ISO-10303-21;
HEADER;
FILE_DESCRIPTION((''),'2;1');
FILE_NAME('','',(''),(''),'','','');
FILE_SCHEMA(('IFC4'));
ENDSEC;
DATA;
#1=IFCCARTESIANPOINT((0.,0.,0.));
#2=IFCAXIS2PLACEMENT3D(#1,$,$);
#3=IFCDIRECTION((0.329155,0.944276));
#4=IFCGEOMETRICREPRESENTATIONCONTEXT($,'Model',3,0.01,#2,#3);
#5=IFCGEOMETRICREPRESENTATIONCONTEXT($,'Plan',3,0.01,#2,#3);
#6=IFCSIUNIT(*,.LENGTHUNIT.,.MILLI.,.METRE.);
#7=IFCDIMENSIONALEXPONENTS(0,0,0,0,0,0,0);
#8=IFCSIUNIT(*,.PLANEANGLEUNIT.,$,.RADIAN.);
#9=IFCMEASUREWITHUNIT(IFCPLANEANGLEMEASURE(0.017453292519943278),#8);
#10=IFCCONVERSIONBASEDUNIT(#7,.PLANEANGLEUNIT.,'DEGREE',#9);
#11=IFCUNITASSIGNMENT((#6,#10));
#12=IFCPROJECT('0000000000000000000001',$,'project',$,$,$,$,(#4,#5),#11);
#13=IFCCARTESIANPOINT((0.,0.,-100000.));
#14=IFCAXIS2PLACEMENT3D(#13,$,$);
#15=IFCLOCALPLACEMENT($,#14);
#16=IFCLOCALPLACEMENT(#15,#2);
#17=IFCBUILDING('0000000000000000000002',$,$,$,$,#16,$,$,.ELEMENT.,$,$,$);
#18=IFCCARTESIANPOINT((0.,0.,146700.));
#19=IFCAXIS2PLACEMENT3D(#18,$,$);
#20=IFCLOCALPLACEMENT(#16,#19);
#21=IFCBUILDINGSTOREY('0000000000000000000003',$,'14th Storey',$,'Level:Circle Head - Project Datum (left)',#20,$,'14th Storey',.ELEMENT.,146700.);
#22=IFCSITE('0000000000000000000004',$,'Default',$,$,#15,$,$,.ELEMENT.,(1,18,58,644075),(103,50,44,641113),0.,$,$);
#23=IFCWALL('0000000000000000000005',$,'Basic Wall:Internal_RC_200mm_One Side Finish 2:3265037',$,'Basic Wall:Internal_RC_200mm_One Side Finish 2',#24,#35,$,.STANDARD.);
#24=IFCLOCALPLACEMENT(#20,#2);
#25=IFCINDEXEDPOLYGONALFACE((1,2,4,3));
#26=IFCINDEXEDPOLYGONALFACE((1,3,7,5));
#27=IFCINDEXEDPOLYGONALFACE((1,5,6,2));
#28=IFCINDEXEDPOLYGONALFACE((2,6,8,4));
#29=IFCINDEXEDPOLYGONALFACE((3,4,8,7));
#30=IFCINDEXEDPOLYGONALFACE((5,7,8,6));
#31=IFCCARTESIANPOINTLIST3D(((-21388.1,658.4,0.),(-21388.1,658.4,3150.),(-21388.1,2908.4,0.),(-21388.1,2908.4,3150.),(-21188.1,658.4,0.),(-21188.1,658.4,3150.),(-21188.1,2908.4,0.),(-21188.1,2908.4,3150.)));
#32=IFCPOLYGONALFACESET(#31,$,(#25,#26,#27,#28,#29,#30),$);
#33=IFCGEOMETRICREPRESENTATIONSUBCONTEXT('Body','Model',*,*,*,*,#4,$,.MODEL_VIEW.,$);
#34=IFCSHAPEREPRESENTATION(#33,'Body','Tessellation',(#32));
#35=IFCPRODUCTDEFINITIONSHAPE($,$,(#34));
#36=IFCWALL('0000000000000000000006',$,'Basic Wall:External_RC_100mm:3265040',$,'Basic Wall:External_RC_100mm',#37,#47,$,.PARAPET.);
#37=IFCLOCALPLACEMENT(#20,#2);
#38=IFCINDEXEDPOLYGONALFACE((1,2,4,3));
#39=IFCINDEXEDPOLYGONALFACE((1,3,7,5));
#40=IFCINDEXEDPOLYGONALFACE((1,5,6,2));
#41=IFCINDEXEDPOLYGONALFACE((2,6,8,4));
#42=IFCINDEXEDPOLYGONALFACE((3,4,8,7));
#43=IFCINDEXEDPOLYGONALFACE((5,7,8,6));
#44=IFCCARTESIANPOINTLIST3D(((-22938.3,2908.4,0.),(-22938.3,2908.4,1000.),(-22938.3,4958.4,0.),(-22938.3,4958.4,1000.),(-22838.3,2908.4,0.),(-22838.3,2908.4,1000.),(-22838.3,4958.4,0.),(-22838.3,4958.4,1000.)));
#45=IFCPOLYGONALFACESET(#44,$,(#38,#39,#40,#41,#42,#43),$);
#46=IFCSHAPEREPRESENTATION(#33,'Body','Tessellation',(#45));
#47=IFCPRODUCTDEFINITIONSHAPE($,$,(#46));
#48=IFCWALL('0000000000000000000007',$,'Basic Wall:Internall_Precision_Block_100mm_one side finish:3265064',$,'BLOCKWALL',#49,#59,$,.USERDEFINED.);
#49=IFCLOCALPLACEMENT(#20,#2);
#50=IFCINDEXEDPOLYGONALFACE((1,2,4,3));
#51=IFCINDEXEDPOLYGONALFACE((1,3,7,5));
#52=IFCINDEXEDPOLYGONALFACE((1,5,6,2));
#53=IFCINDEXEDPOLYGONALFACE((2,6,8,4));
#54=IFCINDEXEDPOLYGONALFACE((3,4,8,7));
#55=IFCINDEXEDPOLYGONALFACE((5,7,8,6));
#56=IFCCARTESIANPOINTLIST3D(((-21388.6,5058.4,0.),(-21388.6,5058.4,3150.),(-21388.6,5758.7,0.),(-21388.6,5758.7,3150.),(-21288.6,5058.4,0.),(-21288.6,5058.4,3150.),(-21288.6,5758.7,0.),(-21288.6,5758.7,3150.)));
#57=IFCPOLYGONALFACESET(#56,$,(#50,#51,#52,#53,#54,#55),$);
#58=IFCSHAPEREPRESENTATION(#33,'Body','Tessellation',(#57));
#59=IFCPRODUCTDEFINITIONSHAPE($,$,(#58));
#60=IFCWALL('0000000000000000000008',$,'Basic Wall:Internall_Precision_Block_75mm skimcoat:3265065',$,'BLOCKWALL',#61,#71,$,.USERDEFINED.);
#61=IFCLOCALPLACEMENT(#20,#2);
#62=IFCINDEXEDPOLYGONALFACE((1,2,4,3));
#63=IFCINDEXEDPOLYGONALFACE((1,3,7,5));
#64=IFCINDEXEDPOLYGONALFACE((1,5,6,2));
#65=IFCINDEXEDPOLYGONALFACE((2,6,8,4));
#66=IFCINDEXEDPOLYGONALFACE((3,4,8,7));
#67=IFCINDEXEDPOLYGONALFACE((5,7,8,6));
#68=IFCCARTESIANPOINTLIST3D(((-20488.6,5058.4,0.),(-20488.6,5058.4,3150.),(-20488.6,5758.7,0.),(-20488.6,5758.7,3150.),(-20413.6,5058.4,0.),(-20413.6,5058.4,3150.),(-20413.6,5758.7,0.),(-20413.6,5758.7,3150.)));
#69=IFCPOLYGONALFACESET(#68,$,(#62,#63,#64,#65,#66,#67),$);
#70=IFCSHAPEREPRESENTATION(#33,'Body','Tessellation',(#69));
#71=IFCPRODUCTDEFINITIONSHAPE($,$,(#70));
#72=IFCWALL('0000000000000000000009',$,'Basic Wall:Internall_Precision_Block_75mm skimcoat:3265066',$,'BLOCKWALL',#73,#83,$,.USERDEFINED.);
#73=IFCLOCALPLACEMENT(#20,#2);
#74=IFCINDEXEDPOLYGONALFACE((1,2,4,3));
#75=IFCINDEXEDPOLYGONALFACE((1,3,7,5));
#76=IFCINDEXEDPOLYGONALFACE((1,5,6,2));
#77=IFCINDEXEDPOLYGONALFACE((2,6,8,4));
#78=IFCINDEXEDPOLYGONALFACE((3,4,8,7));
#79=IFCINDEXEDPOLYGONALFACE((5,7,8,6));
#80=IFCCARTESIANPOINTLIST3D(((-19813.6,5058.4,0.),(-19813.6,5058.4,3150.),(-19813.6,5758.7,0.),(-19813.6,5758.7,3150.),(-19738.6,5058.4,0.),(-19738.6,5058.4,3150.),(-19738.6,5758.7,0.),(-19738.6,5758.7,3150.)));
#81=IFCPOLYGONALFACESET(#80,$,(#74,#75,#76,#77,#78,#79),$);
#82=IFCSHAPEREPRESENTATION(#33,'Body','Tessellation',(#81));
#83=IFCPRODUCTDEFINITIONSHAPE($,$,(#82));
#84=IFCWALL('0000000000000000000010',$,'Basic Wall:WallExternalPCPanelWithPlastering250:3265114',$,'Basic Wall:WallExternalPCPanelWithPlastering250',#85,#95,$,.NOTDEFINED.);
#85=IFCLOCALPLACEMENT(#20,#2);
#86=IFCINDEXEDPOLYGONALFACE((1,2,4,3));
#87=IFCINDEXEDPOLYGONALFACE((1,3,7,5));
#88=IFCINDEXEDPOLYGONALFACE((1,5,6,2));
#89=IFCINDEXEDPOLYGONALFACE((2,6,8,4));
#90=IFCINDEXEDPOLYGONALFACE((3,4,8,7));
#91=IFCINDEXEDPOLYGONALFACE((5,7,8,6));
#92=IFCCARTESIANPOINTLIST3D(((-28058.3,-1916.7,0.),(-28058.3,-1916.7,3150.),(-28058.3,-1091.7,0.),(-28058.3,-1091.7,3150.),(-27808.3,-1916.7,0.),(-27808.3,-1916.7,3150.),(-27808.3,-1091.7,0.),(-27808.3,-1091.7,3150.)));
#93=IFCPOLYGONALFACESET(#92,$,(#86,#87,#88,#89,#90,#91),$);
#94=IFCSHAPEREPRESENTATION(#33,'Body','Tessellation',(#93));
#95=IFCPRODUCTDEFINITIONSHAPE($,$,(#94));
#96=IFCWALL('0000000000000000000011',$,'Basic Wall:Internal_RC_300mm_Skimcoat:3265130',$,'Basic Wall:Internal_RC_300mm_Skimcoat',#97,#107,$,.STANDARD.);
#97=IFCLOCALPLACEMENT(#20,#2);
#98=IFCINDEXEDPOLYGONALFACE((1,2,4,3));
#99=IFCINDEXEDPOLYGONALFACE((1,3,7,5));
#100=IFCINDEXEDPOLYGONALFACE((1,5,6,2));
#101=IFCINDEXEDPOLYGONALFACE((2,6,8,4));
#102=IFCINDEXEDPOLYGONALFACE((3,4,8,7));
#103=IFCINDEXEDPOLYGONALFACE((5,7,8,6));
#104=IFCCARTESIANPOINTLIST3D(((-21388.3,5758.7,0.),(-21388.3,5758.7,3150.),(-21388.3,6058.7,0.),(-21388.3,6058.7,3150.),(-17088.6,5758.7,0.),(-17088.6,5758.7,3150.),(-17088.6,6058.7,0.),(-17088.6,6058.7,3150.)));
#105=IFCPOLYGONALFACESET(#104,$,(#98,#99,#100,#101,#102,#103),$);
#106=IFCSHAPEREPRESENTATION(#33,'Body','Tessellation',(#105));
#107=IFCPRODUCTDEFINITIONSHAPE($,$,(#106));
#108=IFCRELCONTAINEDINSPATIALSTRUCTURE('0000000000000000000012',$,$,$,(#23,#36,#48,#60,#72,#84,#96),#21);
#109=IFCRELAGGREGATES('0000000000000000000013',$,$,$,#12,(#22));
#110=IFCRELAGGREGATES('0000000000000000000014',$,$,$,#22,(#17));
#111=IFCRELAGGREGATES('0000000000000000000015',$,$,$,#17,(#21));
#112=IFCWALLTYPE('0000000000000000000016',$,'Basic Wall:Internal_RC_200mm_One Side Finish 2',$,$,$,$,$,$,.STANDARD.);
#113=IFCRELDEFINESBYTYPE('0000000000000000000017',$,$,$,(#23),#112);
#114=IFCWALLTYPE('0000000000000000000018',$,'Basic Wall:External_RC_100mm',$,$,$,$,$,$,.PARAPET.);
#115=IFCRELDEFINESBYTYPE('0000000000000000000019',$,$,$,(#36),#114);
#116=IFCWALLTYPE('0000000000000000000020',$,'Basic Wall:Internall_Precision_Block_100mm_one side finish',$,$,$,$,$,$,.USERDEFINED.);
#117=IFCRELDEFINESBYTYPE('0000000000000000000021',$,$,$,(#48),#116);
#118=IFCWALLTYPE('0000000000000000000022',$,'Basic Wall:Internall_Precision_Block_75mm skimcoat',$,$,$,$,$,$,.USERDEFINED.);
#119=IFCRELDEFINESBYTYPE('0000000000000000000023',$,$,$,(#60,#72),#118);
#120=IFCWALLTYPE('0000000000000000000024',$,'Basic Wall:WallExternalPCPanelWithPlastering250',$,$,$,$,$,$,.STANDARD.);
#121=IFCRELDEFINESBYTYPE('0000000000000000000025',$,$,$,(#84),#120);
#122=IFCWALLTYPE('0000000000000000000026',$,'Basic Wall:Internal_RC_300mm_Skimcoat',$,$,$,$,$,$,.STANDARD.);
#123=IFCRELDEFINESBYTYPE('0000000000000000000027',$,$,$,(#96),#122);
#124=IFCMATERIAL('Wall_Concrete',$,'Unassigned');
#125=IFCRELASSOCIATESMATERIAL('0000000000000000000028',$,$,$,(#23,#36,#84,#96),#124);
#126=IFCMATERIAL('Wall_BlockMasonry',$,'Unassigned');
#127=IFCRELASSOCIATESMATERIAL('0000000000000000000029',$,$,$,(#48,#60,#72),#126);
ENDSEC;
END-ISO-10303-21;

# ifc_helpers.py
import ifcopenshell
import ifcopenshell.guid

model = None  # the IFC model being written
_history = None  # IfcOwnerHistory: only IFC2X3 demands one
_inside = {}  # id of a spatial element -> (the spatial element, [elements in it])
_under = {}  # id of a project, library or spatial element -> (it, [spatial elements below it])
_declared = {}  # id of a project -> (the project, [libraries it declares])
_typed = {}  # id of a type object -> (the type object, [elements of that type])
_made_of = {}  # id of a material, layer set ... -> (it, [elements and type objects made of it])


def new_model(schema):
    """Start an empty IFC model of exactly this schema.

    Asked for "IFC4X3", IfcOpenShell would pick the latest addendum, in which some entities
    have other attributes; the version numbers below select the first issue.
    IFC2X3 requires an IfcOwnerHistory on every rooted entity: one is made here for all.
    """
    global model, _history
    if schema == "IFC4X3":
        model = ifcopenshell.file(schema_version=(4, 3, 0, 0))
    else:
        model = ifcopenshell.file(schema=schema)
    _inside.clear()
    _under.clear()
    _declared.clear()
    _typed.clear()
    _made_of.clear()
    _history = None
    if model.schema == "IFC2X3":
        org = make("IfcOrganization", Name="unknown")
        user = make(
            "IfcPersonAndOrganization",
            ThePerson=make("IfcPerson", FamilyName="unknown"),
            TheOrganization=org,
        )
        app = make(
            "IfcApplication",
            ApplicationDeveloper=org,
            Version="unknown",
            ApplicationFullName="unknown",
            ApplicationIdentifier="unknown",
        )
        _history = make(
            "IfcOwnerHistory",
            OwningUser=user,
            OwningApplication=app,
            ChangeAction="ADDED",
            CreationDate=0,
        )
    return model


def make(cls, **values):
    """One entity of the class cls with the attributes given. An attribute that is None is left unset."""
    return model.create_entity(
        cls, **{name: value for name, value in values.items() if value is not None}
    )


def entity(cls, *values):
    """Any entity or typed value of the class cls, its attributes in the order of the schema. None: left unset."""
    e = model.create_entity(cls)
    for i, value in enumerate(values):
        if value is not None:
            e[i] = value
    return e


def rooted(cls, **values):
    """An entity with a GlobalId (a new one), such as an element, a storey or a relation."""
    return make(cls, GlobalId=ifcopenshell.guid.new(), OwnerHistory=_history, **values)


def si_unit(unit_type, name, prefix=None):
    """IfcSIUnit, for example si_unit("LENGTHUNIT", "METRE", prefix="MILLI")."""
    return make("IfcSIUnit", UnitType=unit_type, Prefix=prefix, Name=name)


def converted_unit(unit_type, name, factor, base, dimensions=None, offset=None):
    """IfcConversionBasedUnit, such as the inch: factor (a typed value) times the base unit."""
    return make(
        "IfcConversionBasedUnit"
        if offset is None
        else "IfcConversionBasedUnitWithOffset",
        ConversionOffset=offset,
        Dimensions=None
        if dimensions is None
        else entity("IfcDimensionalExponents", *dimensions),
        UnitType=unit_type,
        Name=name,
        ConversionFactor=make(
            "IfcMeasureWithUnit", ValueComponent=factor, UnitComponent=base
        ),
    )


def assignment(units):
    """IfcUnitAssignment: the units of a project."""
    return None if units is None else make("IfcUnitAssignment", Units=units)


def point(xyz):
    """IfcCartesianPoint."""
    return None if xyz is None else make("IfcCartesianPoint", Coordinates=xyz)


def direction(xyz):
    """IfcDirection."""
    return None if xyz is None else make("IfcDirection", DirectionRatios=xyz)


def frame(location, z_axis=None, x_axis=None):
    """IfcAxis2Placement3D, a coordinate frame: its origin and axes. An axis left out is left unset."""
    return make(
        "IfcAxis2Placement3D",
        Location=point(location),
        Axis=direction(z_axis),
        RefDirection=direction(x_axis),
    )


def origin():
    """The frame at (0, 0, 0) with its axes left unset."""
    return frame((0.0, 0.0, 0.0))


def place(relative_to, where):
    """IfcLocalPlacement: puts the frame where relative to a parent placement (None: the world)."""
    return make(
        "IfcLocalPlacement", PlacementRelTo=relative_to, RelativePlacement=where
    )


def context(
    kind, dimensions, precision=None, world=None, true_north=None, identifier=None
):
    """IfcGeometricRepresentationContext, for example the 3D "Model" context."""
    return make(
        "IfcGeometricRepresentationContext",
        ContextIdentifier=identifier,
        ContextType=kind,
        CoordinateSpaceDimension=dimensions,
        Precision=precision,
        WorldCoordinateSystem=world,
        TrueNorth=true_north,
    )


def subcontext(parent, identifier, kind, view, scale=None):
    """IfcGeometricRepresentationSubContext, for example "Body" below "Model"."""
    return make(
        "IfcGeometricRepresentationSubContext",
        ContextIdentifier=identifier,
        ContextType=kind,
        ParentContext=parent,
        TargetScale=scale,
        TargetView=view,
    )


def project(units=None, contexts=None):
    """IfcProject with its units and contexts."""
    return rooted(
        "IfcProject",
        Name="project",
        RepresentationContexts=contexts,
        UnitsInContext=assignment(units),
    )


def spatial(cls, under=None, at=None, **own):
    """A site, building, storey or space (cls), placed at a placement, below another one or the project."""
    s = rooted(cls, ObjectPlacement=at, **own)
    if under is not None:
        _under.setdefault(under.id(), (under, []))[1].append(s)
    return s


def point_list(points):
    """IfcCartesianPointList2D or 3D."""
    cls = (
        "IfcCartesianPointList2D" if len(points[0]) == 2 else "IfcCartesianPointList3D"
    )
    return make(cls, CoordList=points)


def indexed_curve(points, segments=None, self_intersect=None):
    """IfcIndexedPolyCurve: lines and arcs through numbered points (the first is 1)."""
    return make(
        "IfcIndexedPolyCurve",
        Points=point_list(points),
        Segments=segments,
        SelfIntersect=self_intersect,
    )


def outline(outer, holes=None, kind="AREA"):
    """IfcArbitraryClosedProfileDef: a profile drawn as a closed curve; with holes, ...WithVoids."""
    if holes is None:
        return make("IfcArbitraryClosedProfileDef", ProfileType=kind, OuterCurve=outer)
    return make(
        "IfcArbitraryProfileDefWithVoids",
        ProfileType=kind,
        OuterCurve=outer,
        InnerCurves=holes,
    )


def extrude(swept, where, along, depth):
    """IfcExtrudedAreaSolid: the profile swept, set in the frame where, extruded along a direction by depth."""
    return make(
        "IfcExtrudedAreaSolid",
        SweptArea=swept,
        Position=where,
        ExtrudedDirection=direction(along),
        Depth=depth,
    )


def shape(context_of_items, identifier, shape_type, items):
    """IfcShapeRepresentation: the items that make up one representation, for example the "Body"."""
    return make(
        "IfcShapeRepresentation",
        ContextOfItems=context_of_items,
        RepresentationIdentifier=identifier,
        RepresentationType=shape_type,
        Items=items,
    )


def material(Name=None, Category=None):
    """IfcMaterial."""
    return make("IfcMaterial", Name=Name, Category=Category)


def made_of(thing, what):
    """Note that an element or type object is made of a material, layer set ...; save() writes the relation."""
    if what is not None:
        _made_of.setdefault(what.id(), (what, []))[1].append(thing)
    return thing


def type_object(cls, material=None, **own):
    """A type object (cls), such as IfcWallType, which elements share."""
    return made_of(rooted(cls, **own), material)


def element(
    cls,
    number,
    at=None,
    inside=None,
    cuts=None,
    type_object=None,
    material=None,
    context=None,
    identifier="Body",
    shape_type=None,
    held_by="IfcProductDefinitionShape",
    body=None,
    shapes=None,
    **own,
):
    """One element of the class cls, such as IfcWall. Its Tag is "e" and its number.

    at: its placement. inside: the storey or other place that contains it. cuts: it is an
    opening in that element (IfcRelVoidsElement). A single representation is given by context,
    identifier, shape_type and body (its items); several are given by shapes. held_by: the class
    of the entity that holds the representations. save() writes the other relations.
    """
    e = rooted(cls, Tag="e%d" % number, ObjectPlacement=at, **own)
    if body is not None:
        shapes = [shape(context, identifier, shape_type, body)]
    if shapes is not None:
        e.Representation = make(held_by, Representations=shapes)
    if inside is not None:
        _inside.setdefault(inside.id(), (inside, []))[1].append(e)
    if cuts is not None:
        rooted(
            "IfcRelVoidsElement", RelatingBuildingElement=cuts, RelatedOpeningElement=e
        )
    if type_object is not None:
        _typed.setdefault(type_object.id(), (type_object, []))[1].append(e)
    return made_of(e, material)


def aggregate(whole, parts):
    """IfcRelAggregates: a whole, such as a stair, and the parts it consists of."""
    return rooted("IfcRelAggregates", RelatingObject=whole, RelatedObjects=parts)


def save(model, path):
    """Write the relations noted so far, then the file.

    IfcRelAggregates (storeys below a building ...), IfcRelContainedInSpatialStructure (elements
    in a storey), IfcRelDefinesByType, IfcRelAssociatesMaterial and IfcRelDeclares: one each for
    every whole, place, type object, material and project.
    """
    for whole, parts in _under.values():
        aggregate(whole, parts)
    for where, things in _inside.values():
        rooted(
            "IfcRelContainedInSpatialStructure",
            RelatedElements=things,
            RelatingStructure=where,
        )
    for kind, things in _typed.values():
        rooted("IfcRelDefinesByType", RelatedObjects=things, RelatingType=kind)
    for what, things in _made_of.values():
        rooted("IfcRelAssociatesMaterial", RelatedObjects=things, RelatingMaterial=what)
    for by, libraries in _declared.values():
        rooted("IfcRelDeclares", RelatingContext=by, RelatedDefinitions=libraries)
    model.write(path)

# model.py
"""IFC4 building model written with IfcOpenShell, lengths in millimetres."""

from ifc_helpers import new_model, entity, si_unit, converted_unit, direction, frame, origin, place, context, subcontext, project, spatial, indexed_curve, outline, extrude, material, type_object, element, save


model = new_model("IFC4")

# Units and contexts
model_context = context("Model", 3, precision=0.01, world=origin(), true_north=direction((0.329155, 0.944276)))
plan_context = context("Plan", 3, precision=0.01, world=origin(), true_north=direction((0.329155, 0.944276)))
body_context = subcontext(model_context, "Body", "Model", "MODEL_VIEW")
ifc_project = project(units=[si_unit("LENGTHUNIT", "METRE", prefix="MILLI"), converted_unit("PLANEANGLEUNIT", "DEGREE", entity("IfcPlaneAngleMeasure", 0.017453292519943278), si_unit("PLANEANGLEUNIT", "RADIAN"), dimensions=[0, 0, 0, 0, 0, 0, 0])], contexts=[model_context, plan_context])

# Site, building, storey
site_placement = place(None, frame((0.0, 0.0, -100000.0)))
site = spatial("IfcSite", under=ifc_project, at=site_placement, Name="Default", CompositionType="ELEMENT", RefLatitude=(1, 18, 58, 644075), RefLongitude=(103, 50, 44, 641113), RefElevation=0.0)
building_placement = place(site_placement, origin())
building = spatial("IfcBuilding", under=site, at=building_placement, CompositionType="ELEMENT")
storey_placement = place(building_placement, frame((0.0, 0.0, 146700.0)))
storey = spatial("IfcBuildingStorey", under=building, at=storey_placement, Name="14th Storey", ObjectType="Level:Circle Head - Project Datum (left)", LongName="14th Storey", CompositionType="ELEMENT", Elevation=146700.0)

# Walls
ifc_material_1 = material(Name="Wall_Concrete", Category="Unassigned")
wall_type_1 = type_object("IfcWallType", Name="Basic Wall:Internal_RC_200mm_One Side Finish 2", PredefinedType="STANDARD")
wall_1_placement = place(storey_placement, frame((-21288.1, 658.4, 0.0), z_axis=(0.0, 0.0, 1.0), x_axis=(0.0, 1.0, 0.0)))
element("IfcWall", 1, at=wall_1_placement, inside=storey, type_object=wall_type_1, material=ifc_material_1, Name="Basic Wall:Internal_RC_200mm_One Side Finish 2:3265037", ObjectType="Basic Wall:Internal_RC_200mm_One Side Finish 2", PredefinedType="STANDARD", context=body_context, shape_type="SweptSolid", body=[
    extrude(outline(indexed_curve([(2250.0, 100.0), (0.0, 100.0), (0.0, -100.0), (2250.0, -100.0), (2250.0, 100.0)], self_intersect=False)), origin(), (0.0, 0.0, 1.0), 3150.0),
])
wall_type_2 = type_object("IfcWallType", Name="Basic Wall:External_RC_100mm", PredefinedType="PARAPET")
wall_2_placement = place(storey_placement, frame((-22888.3, 4958.4, 0.0), z_axis=(0.0, 0.0, 1.0), x_axis=(0.0, -1.0, 0.0)))
element("IfcWall", 2, at=wall_2_placement, inside=storey, type_object=wall_type_2, material=ifc_material_1, Name="Basic Wall:External_RC_100mm:3265040", ObjectType="Basic Wall:External_RC_100mm", PredefinedType="PARAPET", context=body_context, shape_type="SweptSolid", body=[
    extrude(outline(indexed_curve([(2050.0, 50.0), (0.0, 50.0), (0.0, -50.0), (2050.0, -50.0), (2050.0, 50.0)], self_intersect=False)), origin(), (0.0, 0.0, 1.0), 1000.0),
])
ifc_material_2 = material(Name="Wall_BlockMasonry", Category="Unassigned")
wall_type_3 = type_object("IfcWallType", Name="Basic Wall:Internall_Precision_Block_100mm_one side finish", PredefinedType="USERDEFINED")
wall_3_placement = place(storey_placement, frame((-21338.6, 5058.4, 0.0), z_axis=(0.0, 0.0, 1.0), x_axis=(0.0, 1.0, 0.0)))
element("IfcWall", 3, at=wall_3_placement, inside=storey, type_object=wall_type_3, material=ifc_material_2, Name="Basic Wall:Internall_Precision_Block_100mm_one side finish:3265064", ObjectType="BLOCKWALL", PredefinedType="USERDEFINED", context=body_context, shape_type="SweptSolid", body=[
    extrude(outline(indexed_curve([(700.4, 50.0), (0.0, 50.0), (0.0, -50.0), (700.4, -50.0), (700.4, 50.0)], self_intersect=False)), origin(), (0.0, 0.0, 1.0), 3150.0),
])
wall_type_4 = type_object("IfcWallType", Name="Basic Wall:Internall_Precision_Block_75mm skimcoat", PredefinedType="USERDEFINED")
wall_4_placement = place(storey_placement, frame((-20451.1, 5058.4, 0.0), z_axis=(0.0, 0.0, 1.0), x_axis=(0.0, 1.0, 0.0)))
element("IfcWall", 4, at=wall_4_placement, inside=storey, type_object=wall_type_4, material=ifc_material_2, Name="Basic Wall:Internall_Precision_Block_75mm skimcoat:3265065", ObjectType="BLOCKWALL", PredefinedType="USERDEFINED", context=body_context, shape_type="SweptSolid", body=[
    extrude(outline(indexed_curve([(700.4, 37.5), (0.0, 37.5), (0.0, -37.5), (700.4, -37.5), (700.4, 37.5)], self_intersect=False)), origin(), (0.0, 0.0, 1.0), 3150.0),
])
wall_5_placement = place(storey_placement, frame((-19776.1, 5058.4, 0.0), z_axis=(0.0, 0.0, 1.0), x_axis=(0.0, 1.0, 0.0)))
element("IfcWall", 5, at=wall_5_placement, inside=storey, type_object=wall_type_4, material=ifc_material_2, Name="Basic Wall:Internall_Precision_Block_75mm skimcoat:3265066", ObjectType="BLOCKWALL", PredefinedType="USERDEFINED", context=body_context, shape_type="SweptSolid", body=[
    extrude(outline(indexed_curve([(700.4, 37.5), (0.0, 37.5), (0.0, -37.5), (700.4, -37.5), (700.4, 37.5)], self_intersect=False)), origin(), (0.0, 0.0, 1.0), 3150.0),
])
wall_type_5 = type_object("IfcWallType", Name="Basic Wall:WallExternalPCPanelWithPlastering250", PredefinedType="STANDARD")
wall_6_placement = place(storey_placement, frame((-27933.3, -1916.7, 0.0), z_axis=(0.0, 0.0, 1.0), x_axis=(0.0, 1.0, 0.0)))
element("IfcWall", 6, at=wall_6_placement, inside=storey, type_object=wall_type_5, material=ifc_material_1, Name="Basic Wall:WallExternalPCPanelWithPlastering250:3265114", ObjectType="Basic Wall:WallExternalPCPanelWithPlastering250", PredefinedType="NOTDEFINED", context=body_context, shape_type="SweptSolid", body=[
    extrude(outline(indexed_curve([(825.0, 125.0), (0.0, 125.0), (0.0, -125.0), (825.0, -125.0), (825.0, 125.0)], self_intersect=False)), origin(), (0.0, 0.0, 1.0), 3150.0),
])
wall_type_6 = type_object("IfcWallType", Name="Basic Wall:Internal_RC_300mm_Skimcoat", PredefinedType="STANDARD")
wall_7_placement = place(storey_placement, frame((-21388.3, 5908.7, 0.0)))
element("IfcWall", 7, at=wall_7_placement, inside=storey, type_object=wall_type_6, material=ifc_material_1, Name="Basic Wall:Internal_RC_300mm_Skimcoat:3265130", ObjectType="Basic Wall:Internal_RC_300mm_Skimcoat", PredefinedType="STANDARD", context=body_context, shape_type="SweptSolid", body=[
    extrude(outline(indexed_curve([(4299.7, 150.0), (0.0, 150.0), (0.0, -150.0), (4299.7, -150.0), (4299.7, 150.0)], self_intersect=False)), origin(), (0.0, 0.0, 1.0), 3150.0),
])

save(model, "model.ifc")
